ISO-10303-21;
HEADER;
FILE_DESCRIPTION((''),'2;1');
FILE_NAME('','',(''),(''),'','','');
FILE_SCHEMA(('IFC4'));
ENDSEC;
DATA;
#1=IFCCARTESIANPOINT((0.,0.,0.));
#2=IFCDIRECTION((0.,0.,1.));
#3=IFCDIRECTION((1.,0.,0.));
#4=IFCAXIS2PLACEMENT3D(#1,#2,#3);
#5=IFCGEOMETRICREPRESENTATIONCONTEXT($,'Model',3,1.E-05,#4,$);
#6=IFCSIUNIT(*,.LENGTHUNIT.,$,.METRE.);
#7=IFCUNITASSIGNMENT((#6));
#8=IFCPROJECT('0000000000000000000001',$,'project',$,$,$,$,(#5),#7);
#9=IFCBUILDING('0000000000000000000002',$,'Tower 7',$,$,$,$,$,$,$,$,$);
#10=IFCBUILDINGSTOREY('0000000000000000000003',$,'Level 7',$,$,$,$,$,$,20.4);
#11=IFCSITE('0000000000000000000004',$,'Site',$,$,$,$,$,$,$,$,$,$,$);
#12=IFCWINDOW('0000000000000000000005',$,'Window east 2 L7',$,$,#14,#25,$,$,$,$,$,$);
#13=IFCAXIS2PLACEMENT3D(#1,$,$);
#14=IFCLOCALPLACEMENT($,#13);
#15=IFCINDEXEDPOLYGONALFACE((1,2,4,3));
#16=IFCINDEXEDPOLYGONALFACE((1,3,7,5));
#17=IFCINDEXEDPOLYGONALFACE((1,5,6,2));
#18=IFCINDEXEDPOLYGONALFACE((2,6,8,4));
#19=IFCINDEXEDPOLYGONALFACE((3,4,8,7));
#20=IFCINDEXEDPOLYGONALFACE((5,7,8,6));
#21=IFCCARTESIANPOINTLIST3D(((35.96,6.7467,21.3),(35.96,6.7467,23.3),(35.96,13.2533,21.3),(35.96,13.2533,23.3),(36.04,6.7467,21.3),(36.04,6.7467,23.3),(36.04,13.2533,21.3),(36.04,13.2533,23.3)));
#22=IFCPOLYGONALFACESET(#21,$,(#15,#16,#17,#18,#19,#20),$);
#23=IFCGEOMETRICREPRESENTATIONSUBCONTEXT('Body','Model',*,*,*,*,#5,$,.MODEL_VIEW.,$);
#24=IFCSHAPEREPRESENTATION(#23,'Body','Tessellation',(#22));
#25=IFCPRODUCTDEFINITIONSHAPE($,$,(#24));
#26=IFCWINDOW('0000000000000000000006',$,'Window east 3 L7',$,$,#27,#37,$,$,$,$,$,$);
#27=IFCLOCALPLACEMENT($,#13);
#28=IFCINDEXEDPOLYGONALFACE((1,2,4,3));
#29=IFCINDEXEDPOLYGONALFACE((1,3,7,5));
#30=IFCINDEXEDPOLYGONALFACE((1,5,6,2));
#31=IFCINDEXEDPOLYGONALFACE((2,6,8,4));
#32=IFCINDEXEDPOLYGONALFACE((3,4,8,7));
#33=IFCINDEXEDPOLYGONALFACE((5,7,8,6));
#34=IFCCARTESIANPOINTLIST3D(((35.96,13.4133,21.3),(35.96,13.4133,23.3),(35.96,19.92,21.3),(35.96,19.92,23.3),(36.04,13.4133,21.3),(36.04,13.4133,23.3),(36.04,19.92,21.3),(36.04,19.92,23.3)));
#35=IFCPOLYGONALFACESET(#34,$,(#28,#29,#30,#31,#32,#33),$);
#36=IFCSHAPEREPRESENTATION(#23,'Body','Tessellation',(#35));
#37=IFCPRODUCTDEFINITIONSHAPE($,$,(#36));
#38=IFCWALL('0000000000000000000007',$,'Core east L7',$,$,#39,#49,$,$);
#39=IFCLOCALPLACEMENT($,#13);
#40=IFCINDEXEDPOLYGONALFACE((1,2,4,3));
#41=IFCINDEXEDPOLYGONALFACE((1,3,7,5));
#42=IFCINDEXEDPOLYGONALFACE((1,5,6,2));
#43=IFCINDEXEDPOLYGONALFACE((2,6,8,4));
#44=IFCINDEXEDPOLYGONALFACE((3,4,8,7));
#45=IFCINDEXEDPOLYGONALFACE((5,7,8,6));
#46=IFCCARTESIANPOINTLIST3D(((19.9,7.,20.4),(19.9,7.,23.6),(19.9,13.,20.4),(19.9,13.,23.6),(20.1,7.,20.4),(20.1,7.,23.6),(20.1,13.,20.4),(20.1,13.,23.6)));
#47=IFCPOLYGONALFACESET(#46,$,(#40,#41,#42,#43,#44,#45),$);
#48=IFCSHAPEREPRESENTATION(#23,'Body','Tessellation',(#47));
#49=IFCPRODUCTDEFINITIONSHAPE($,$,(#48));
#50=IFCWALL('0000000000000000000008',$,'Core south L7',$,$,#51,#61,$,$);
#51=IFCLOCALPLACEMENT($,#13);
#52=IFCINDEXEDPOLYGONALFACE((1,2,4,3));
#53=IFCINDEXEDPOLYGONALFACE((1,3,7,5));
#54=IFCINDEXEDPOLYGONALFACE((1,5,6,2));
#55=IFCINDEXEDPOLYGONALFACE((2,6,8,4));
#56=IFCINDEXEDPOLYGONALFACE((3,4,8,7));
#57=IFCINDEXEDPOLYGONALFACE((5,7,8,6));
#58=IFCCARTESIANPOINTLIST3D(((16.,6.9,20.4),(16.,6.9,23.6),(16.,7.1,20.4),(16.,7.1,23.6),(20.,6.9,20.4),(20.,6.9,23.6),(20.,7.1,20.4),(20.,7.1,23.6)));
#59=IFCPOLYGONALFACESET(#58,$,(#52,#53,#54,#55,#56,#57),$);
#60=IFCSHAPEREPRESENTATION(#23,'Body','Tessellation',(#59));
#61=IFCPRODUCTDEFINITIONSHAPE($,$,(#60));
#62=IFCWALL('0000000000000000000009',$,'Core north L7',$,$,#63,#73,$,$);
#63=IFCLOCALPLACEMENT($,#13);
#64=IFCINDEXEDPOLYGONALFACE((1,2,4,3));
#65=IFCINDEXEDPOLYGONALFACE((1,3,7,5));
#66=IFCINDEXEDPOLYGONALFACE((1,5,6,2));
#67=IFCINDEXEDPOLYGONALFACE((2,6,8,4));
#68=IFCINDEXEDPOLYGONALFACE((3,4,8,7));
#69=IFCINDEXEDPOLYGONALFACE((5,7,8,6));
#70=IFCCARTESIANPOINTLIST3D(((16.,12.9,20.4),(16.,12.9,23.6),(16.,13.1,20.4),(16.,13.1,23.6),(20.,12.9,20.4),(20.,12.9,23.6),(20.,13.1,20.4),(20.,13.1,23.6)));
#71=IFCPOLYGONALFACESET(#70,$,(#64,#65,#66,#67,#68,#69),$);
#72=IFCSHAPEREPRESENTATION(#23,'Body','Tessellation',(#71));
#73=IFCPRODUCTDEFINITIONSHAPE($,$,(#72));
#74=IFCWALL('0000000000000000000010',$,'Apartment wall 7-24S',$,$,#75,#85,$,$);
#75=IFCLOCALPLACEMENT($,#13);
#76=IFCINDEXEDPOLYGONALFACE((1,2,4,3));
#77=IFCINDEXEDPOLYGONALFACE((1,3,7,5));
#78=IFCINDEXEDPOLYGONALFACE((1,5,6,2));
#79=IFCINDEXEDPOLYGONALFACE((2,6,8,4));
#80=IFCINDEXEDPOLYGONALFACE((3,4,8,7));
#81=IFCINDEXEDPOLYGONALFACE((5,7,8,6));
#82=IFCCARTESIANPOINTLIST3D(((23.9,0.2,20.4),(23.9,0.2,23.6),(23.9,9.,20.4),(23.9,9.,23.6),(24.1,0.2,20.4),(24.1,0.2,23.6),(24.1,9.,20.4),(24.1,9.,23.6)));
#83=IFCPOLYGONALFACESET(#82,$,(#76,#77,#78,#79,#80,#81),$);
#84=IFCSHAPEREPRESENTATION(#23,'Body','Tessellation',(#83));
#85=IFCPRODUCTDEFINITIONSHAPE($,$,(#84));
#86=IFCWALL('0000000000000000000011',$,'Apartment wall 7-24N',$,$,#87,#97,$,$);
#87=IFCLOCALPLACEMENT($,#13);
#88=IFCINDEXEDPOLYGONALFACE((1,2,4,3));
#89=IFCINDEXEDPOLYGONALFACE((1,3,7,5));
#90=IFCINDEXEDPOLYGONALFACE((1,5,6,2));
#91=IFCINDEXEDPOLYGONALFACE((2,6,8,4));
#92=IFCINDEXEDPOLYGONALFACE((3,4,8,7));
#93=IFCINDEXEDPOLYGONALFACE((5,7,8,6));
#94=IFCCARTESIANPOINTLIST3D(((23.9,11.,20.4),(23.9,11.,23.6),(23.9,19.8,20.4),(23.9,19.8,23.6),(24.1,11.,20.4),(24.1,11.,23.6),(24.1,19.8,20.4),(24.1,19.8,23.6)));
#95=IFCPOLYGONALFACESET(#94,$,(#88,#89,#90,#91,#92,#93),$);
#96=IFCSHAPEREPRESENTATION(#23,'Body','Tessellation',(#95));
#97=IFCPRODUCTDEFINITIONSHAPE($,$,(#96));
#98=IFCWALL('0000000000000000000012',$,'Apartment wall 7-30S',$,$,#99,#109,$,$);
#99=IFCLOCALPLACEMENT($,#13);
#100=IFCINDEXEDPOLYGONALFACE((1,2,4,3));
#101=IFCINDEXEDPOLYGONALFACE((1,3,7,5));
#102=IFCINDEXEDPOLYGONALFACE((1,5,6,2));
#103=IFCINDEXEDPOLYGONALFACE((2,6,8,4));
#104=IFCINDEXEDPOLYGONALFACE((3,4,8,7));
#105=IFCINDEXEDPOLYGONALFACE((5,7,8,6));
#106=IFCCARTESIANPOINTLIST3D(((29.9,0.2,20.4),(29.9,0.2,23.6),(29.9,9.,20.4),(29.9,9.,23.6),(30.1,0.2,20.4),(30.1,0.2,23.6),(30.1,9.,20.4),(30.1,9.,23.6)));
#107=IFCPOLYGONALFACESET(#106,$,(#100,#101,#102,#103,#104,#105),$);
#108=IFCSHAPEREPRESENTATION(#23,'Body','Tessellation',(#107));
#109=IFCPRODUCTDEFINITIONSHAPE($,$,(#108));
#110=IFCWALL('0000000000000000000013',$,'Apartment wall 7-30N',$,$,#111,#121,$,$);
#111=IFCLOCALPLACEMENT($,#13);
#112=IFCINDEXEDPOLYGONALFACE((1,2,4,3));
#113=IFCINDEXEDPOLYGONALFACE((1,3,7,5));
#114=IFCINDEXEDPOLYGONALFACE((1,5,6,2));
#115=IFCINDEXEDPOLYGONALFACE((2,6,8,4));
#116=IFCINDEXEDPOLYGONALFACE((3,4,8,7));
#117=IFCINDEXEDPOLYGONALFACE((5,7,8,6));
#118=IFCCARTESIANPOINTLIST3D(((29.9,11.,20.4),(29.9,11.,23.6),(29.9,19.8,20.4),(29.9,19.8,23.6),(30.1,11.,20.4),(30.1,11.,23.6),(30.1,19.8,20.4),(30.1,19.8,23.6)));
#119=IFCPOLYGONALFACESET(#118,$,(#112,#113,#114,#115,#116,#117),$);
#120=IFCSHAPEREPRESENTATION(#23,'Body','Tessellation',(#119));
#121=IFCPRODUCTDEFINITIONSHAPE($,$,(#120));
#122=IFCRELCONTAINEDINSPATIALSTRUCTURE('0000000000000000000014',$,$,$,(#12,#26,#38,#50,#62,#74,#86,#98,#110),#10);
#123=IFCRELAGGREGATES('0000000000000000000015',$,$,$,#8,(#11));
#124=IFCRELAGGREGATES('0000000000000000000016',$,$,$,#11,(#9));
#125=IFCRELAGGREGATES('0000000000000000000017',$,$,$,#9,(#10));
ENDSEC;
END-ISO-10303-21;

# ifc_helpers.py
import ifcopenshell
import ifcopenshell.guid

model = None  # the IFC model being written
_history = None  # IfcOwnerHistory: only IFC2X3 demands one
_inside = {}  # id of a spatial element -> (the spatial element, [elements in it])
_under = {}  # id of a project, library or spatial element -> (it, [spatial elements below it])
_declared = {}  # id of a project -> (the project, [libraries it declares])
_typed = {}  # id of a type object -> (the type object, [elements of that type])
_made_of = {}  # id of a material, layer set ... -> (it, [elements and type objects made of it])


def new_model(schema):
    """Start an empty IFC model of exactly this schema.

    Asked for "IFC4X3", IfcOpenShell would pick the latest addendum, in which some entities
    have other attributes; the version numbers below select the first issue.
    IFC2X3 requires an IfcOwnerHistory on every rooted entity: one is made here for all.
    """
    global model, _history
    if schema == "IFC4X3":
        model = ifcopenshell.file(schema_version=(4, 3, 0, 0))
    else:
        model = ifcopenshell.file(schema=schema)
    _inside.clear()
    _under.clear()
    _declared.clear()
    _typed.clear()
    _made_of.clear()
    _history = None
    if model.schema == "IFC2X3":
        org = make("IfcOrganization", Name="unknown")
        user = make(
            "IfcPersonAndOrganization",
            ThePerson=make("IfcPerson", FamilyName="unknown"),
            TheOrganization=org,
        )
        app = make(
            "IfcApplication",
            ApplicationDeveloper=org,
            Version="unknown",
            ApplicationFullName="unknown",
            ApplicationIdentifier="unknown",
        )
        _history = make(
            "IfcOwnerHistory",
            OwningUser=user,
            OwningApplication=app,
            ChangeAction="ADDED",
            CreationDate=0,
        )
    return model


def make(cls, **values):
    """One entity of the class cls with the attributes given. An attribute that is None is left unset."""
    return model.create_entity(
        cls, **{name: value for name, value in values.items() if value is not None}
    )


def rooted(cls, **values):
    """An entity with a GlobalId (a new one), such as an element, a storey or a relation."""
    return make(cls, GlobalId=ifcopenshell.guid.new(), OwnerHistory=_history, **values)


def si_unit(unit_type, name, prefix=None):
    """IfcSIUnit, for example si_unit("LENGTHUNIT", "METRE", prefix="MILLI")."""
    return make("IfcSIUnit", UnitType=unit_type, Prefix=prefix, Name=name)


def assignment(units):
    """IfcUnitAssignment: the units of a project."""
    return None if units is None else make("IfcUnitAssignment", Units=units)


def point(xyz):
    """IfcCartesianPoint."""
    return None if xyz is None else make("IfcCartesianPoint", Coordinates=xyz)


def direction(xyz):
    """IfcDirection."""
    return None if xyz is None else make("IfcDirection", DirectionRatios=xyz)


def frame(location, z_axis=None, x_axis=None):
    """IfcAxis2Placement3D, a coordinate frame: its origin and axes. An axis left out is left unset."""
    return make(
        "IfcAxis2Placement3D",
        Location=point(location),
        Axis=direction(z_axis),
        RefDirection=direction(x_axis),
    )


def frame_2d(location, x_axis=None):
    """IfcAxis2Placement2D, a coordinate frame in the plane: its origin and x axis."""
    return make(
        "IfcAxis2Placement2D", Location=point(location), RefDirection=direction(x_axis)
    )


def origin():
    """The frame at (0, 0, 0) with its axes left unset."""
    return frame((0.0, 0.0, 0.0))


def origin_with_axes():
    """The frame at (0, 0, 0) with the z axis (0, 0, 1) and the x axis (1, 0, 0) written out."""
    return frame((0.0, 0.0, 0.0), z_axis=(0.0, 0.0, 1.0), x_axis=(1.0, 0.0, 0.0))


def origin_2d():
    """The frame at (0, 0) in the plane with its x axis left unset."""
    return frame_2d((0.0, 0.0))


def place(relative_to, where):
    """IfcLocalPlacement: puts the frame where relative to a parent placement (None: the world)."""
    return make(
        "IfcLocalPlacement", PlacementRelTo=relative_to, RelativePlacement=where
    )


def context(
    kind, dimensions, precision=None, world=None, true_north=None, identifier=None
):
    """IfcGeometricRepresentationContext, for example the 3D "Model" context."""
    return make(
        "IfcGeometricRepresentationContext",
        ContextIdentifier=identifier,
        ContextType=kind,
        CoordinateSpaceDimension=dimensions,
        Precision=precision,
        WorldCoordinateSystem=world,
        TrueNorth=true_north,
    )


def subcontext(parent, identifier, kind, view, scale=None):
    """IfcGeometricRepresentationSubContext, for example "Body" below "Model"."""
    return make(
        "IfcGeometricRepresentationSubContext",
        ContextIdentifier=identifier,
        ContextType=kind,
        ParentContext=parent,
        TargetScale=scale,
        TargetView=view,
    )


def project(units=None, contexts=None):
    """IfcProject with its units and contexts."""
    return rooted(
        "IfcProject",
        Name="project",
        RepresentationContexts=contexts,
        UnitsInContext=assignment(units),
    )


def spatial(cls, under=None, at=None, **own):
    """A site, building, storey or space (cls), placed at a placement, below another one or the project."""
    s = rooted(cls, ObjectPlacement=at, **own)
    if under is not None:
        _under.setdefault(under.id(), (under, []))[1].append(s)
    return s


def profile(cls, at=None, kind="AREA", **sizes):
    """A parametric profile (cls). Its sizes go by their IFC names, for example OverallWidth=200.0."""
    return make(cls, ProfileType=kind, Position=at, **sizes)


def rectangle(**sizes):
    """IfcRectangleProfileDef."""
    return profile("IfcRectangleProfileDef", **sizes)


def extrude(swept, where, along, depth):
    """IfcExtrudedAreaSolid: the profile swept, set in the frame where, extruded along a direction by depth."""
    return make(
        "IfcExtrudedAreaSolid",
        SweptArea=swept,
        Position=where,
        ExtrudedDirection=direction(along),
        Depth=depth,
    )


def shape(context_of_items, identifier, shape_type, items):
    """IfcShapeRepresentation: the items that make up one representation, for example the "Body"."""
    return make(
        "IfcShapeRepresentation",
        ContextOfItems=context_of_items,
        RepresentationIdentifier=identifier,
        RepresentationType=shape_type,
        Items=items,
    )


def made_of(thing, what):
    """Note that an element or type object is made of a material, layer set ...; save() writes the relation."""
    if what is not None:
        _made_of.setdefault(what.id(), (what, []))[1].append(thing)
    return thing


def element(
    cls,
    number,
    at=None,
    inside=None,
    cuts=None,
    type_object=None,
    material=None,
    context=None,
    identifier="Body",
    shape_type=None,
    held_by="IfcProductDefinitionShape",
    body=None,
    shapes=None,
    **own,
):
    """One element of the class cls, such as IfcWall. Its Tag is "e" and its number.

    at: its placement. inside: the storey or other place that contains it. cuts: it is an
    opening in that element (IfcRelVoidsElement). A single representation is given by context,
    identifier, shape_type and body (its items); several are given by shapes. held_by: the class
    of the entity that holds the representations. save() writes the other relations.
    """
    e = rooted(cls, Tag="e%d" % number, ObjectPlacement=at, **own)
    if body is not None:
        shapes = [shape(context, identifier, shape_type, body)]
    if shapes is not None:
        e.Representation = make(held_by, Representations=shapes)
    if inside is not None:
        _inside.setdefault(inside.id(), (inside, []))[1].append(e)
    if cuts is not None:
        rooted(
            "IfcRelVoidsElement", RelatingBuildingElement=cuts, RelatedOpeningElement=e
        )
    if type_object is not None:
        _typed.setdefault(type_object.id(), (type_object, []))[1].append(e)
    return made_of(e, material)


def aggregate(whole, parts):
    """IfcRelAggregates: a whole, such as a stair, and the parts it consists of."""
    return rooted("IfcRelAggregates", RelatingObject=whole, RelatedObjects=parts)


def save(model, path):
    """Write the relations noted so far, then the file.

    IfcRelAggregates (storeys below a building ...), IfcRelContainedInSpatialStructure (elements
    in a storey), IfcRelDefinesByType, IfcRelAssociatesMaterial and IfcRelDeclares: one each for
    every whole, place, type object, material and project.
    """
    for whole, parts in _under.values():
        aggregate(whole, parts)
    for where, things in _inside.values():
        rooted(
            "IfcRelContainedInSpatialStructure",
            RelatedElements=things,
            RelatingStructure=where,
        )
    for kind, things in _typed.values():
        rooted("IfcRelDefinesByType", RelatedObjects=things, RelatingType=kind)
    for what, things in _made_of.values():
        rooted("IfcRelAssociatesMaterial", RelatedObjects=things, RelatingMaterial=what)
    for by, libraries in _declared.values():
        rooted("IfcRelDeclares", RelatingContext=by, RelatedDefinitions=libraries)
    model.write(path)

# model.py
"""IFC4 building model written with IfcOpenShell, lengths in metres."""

from ifc_helpers import new_model, si_unit, frame, origin, origin_with_axes, origin_2d, place, context, subcontext, project, spatial, rectangle, extrude, element, save


model = new_model("IFC4")

# Units and contexts
model_context = context("Model", 3, precision=1e-05, world=origin_with_axes())
body_context = subcontext(model_context, "Body", "Model", "MODEL_VIEW")
ifc_project = project(units=[si_unit("LENGTHUNIT", "METRE")], contexts=[model_context])

# Site, building, storey
site = spatial("IfcSite", under=ifc_project, Name="Site")
building = spatial("IfcBuilding", under=site, Name="Tower 7")
storey = spatial("IfcBuildingStorey", under=building, Name="Level 7", Elevation=20.4)

# Windows
for number, where, z_axis, x_axis, name in (
    (1, (36.0, 10.0, 21.3), (0.0, 0.0, 1.0), (1.0, 0.0, 0.0), "Window east 2 L7"),
):
    element("IfcWindow", number, at=place(None, frame(where, z_axis=z_axis, x_axis=x_axis)), inside=storey, Name=name, context=body_context, shape_type="SweptSolid", body=[
        extrude(rectangle(XDim=0.08, YDim=6.5067, at=origin_2d()), origin(), (0.0, 0.0, 1.0), 2.0),
    ])
window_placement = place(None, frame((36.0, 16.6667, 21.3), z_axis=(0.0, 0.0, 1.0), x_axis=(1.0, 0.0, 0.0)))
element("IfcWindow", 2, at=window_placement, inside=storey, Name="Window east 3 L7", context=body_context, shape_type="SweptSolid", body=[
    extrude(rectangle(XDim=0.08, YDim=6.5067, at=origin_2d()), origin(), (0.0, 0.0, 1.0), 2.0),
])

# Walls
wall_1_placement = place(None, frame((20.0, 10.0, 20.4), z_axis=(0.0, 0.0, 1.0), x_axis=(1.0, 0.0, 0.0)))
element("IfcWall", 3, at=wall_1_placement, inside=storey, Name="Core east L7", context=body_context, shape_type="SweptSolid", body=[
    extrude(rectangle(XDim=0.2, YDim=6.0, at=origin_2d()), origin(), (0.0, 0.0, 1.0), 3.2),
])
for number, where, z_axis, x_axis, name in (
    (4, (18.0, 7.0, 20.4), (0.0, 0.0, 1.0), (1.0, 0.0, 0.0), "Core south L7"),
    (5, (18.0, 13.0, 20.4), (0.0, 0.0, 1.0), (1.0, 0.0, 0.0), "Core north L7"),
):
    element("IfcWall", number, at=place(None, frame(where, z_axis=z_axis, x_axis=x_axis)), inside=storey, Name=name, context=body_context, shape_type="SweptSolid", body=[
        extrude(rectangle(XDim=4.0, YDim=0.2, at=origin_2d()), origin(), (0.0, 0.0, 1.0), 3.2),
    ])
for number, where, z_axis, x_axis, name in (
    (6, (24.0, 4.6, 20.4), (0.0, 0.0, 1.0), (1.0, 0.0, 0.0), "Apartment wall 7-24S"),
    (7, (24.0, 15.4, 20.4), (0.0, 0.0, 1.0), (1.0, 0.0, 0.0), "Apartment wall 7-24N"),
    (8, (30.0, 4.6, 20.4), (0.0, 0.0, 1.0), (1.0, 0.0, 0.0), "Apartment wall 7-30S"),
    (9, (30.0, 15.4, 20.4), (0.0, 0.0, 1.0), (1.0, 0.0, 0.0), "Apartment wall 7-30N"),
):
    element("IfcWall", number, at=place(None, frame(where, z_axis=z_axis, x_axis=x_axis)), inside=storey, Name=name, context=body_context, shape_type="SweptSolid", body=[
        extrude(rectangle(XDim=0.2, YDim=8.8, at=origin_2d()), origin(), (0.0, 0.0, 1.0), 3.2),
    ])

save(model, "model.ifc")
